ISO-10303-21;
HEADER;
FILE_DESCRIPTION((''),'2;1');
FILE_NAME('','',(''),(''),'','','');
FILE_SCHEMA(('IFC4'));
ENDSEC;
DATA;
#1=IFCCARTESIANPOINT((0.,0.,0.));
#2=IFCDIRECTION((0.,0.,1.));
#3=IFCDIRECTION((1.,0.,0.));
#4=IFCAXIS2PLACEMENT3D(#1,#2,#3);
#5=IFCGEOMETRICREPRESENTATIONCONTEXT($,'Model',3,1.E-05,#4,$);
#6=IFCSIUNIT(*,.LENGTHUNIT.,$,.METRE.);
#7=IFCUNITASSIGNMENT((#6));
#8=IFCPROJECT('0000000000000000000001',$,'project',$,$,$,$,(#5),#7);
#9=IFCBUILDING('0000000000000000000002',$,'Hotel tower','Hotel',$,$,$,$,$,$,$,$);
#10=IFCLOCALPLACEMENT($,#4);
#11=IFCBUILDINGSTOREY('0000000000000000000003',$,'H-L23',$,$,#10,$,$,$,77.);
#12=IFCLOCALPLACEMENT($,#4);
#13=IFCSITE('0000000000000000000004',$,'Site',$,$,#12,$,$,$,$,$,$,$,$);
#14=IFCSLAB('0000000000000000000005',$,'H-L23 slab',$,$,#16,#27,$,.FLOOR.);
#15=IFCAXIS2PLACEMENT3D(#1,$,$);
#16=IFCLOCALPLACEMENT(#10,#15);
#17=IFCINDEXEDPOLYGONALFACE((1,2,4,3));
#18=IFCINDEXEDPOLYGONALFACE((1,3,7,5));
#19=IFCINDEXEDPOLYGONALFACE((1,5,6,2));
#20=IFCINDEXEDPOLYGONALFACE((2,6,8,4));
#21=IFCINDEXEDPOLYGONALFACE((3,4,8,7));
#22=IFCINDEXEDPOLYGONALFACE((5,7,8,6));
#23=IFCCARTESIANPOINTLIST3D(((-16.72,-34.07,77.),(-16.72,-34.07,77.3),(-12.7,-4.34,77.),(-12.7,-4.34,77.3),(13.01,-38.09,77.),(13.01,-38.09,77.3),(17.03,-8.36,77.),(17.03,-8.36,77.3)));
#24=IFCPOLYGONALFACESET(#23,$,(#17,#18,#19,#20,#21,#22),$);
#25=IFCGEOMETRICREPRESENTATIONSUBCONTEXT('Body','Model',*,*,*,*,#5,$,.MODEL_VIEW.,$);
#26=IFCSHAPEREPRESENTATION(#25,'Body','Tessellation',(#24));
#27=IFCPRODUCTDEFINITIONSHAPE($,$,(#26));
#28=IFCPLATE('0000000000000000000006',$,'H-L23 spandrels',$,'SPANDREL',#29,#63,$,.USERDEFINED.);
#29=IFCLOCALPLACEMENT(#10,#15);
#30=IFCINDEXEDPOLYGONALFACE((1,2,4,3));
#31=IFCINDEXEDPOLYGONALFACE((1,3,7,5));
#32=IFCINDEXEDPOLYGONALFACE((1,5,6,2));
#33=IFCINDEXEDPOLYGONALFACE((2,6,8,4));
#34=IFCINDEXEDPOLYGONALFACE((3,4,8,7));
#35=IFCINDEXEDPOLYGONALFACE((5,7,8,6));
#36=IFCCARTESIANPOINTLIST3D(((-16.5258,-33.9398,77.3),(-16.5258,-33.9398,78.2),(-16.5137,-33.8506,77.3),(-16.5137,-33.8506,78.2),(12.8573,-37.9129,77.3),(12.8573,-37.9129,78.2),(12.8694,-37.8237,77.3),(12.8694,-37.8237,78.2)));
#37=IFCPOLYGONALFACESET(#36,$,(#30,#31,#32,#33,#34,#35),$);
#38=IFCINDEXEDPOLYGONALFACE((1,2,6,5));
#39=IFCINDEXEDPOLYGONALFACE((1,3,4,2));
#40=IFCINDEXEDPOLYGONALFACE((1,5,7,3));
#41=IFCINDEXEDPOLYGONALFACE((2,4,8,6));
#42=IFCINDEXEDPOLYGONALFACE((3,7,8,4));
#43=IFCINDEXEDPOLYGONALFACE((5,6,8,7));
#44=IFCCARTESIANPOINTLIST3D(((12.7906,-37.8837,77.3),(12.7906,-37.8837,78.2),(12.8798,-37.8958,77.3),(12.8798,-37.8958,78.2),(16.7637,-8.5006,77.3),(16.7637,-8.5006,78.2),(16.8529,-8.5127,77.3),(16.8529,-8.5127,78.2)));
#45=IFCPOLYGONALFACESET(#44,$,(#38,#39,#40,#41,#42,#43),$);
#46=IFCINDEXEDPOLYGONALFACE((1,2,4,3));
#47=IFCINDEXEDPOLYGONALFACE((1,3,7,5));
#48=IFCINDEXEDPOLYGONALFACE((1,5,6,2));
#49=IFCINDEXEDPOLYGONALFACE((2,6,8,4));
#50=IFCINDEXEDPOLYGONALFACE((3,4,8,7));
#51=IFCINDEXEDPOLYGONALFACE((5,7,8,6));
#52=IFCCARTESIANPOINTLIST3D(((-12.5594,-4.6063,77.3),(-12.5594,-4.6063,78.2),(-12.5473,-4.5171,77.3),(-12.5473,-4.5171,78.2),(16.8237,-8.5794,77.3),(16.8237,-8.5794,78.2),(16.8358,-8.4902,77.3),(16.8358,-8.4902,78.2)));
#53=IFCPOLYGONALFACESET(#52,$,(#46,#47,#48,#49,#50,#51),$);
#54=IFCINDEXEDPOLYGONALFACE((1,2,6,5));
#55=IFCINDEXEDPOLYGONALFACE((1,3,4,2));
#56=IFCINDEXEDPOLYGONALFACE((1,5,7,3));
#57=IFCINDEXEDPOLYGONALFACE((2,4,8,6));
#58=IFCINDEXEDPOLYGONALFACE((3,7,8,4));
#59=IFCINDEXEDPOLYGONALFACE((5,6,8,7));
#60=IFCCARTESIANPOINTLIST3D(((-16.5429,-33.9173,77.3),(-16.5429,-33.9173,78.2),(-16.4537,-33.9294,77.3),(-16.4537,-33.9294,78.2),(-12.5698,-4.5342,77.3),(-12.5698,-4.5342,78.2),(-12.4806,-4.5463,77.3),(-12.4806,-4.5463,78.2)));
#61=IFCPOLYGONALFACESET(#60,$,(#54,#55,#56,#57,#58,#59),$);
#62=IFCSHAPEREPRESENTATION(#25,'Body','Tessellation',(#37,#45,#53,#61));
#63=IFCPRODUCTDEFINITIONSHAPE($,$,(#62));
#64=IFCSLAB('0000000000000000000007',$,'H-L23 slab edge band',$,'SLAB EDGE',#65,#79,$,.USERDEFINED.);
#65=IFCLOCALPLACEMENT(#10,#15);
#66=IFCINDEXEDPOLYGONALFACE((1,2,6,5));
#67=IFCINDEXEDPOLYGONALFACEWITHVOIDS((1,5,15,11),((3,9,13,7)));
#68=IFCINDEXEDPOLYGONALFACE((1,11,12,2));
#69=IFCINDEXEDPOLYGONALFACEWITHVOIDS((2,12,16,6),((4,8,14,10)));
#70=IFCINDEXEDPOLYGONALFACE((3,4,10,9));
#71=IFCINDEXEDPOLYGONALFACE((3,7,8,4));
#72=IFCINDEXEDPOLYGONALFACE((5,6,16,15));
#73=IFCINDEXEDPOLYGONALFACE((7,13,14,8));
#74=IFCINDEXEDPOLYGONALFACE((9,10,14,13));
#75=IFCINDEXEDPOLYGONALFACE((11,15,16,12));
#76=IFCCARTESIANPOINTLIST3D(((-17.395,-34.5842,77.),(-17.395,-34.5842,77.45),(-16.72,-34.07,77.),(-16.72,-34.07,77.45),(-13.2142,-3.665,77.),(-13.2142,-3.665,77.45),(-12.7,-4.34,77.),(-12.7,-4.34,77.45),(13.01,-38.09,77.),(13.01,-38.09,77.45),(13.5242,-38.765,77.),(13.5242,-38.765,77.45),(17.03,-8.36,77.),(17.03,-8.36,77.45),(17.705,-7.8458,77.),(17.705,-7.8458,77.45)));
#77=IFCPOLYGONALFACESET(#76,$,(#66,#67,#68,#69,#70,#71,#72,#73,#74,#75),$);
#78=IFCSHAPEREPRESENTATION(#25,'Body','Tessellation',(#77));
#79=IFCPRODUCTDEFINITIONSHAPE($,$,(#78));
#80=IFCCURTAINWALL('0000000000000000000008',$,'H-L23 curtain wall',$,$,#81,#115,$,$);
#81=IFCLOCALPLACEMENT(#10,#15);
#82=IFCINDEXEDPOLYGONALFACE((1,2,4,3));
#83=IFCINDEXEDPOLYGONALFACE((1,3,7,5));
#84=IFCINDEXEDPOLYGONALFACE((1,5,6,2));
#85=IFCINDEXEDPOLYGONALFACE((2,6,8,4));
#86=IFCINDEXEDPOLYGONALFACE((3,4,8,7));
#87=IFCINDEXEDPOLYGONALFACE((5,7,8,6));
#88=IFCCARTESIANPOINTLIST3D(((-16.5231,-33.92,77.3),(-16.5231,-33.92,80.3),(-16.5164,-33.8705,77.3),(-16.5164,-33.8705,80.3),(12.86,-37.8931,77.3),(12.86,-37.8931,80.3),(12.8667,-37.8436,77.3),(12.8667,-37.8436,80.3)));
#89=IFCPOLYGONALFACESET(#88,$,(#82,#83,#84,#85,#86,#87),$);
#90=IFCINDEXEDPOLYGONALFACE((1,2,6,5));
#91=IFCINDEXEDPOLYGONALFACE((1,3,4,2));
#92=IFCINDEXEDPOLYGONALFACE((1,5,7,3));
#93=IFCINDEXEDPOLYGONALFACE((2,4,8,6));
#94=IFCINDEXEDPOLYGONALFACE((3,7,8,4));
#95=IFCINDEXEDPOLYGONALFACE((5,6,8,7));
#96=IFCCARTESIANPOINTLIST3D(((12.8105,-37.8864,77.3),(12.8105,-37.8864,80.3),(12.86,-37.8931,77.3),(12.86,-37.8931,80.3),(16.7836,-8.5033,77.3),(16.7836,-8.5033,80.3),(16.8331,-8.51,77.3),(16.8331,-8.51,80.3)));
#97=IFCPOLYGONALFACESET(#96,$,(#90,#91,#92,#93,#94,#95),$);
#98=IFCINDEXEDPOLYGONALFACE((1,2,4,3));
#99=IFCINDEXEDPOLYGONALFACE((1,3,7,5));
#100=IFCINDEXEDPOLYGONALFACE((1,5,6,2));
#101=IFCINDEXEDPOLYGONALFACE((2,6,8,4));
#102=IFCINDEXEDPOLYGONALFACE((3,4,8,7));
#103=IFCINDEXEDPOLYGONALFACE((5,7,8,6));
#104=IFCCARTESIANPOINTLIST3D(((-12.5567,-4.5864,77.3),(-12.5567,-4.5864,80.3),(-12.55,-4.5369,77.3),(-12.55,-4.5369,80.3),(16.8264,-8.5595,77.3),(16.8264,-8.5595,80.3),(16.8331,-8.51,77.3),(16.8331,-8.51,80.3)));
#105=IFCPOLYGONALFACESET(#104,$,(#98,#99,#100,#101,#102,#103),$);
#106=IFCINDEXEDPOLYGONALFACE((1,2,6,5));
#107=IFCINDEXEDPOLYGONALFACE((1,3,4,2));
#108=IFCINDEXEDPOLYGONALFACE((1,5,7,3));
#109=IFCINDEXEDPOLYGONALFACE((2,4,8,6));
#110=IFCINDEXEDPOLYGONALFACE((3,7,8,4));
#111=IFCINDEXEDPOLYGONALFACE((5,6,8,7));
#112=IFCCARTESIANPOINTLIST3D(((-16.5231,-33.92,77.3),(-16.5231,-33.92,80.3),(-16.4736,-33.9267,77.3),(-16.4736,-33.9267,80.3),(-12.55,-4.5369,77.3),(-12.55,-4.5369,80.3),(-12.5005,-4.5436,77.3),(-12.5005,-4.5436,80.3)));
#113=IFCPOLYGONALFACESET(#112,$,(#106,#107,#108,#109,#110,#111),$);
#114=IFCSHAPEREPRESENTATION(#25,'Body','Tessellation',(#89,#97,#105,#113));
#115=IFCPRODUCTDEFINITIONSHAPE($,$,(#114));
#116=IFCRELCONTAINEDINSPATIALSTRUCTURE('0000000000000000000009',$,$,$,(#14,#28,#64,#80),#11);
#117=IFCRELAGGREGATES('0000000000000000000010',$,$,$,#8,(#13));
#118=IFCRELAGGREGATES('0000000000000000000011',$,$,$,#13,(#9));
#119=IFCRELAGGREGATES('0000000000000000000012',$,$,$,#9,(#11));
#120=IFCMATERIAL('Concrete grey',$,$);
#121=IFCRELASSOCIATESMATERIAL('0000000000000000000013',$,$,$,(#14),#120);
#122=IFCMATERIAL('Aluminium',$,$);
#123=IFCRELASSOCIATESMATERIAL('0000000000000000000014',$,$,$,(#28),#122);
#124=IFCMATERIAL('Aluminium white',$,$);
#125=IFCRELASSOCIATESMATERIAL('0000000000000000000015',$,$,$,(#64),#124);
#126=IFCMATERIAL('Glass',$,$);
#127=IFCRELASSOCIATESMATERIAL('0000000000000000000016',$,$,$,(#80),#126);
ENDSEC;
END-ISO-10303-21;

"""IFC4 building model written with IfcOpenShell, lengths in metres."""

from ifc_helpers import new_model, si_unit, frame, origin_with_axes, place, context, subcontext, project, spatial, polyline, outline, extrude, material, element, save


model = new_model("IFC4")

# Units and contexts
model_context = context("Model", 3, precision=1e-05, world=origin_with_axes())
body_context = subcontext(model_context, "Body", "Model", "MODEL_VIEW")
ifc_project = project(units=[si_unit("LENGTHUNIT", "METRE")], contexts=[model_context])

# Site, building, storey
site_placement = place(None, origin_with_axes())
site = spatial("IfcSite", under=ifc_project, at=site_placement, Name="Site")
building = spatial("IfcBuilding", under=site, Name="Hotel tower", Description="Hotel")
storey_placement = place(None, origin_with_axes())
storey = spatial("IfcBuildingStorey", under=building, at=storey_placement, Name="H-L23", Elevation=77.0)

# Shared definitions
ifc_material_1 = material(Name="Aluminium")

# Slab
ifc_material_2 = material(Name="Concrete grey")
slab_1_placement = place(storey_placement, origin_with_axes())
element("IfcSlab", 1, at=slab_1_placement, inside=storey, material=ifc_material_2, Name="H-L23 slab", PredefinedType="FLOOR", context=body_context, shape_type="SweptSolid", body=[
    extrude(outline(polyline([(-16.72, -34.07), (13.01, -38.09), (17.03, -8.36), (-12.7, -4.34), (-16.72, -34.07)])), frame((0.0, 0.0, 77.0), z_axis=(0.0, 0.0, 1.0), x_axis=(1.0, 0.0, 0.0)), (0.0, 0.0, 1.0), 0.3),
])

# Plate
plate_placement = place(storey_placement, origin_with_axes())
element("IfcPlate", 2, at=plate_placement, inside=storey, material=ifc_material_1, Name="H-L23 spandrels", ObjectType="SPANDREL", PredefinedType="USERDEFINED", context=body_context, shape_type="SweptSolid", body=[
    extrude(outline(polyline([(-16.5258, -33.9398), (12.8573, -37.9129), (12.8694, -37.8237), (-16.5137, -33.8506), (-16.5258, -33.9398)])), frame((0.0, 0.0, 77.3), z_axis=(0.0, 0.0, 1.0), x_axis=(1.0, 0.0, 0.0)), (0.0, 0.0, 1.0), 0.9),
    extrude(outline(polyline([(12.8798, -37.8958), (16.8529, -8.5127), (16.7637, -8.5006), (12.7906, -37.8837), (12.8798, -37.8958)])), frame((0.0, 0.0, 77.3), z_axis=(0.0, 0.0, 1.0), x_axis=(1.0, 0.0, 0.0)), (0.0, 0.0, 1.0), 0.9),
    extrude(outline(polyline([(16.8358, -8.4902), (-12.5473, -4.5171), (-12.5594, -4.6063), (16.8237, -8.5794), (16.8358, -8.4902)])), frame((0.0, 0.0, 77.3), z_axis=(0.0, 0.0, 1.0), x_axis=(1.0, 0.0, 0.0)), (0.0, 0.0, 1.0), 0.9),
    extrude(outline(polyline([(-12.5698, -4.5342), (-16.5429, -33.9173), (-16.4537, -33.9294), (-12.4806, -4.5463), (-12.5698, -4.5342)])), frame((0.0, 0.0, 77.3), z_axis=(0.0, 0.0, 1.0), x_axis=(1.0, 0.0, 0.0)), (0.0, 0.0, 1.0), 0.9),
])

# Slab
ifc_material_3 = material(Name="Aluminium white")
slab_2_placement = place(storey_placement, origin_with_axes())
element("IfcSlab", 3, at=slab_2_placement, inside=storey, material=ifc_material_3, Name="H-L23 slab edge band", ObjectType="SLAB EDGE", PredefinedType="USERDEFINED", context=body_context, shape_type="SweptSolid", body=[
    extrude(outline(polyline([(-17.395, -34.5842), (13.5242, -38.765), (17.705, -7.8458), (-13.2142, -3.665), (-17.395, -34.5842)]), holes=[polyline([(-16.72, -34.07), (13.01, -38.09), (17.03, -8.36), (-12.7, -4.34), (-16.72, -34.07)])]), frame((0.0, 0.0, 77.0), z_axis=(0.0, 0.0, 1.0), x_axis=(1.0, 0.0, 0.0)), (0.0, 0.0, 1.0), 0.45),
])

# Curtain wall
ifc_material_4 = material(Name="Glass")
curtain_wall_placement = place(storey_placement, origin_with_axes())
element("IfcCurtainWall", 4, at=curtain_wall_placement, inside=storey, material=ifc_material_4, Name="H-L23 curtain wall", context=body_context, shape_type="SweptSolid", body=[
    extrude(outline(polyline([(-16.5231, -33.92), (12.86, -37.8931), (12.8667, -37.8436), (-16.5164, -33.8705), (-16.5231, -33.92)])), frame((0.0, 0.0, 77.3), z_axis=(0.0, 0.0, 1.0), x_axis=(1.0, 0.0, 0.0)), (0.0, 0.0, 1.0), 3.0),
    extrude(outline(polyline([(12.86, -37.8931), (16.8331, -8.51), (16.7836, -8.5033), (12.8105, -37.8864), (12.86, -37.8931)])), frame((0.0, 0.0, 77.3), z_axis=(0.0, 0.0, 1.0), x_axis=(1.0, 0.0, 0.0)), (0.0, 0.0, 1.0), 3.0),
    extrude(outline(polyline([(16.8331, -8.51), (-12.55, -4.5369), (-12.5567, -4.5864), (16.8264, -8.5595), (16.8331, -8.51)])), frame((0.0, 0.0, 77.3), z_axis=(0.0, 0.0, 1.0), x_axis=(1.0, 0.0, 0.0)), (0.0, 0.0, 1.0), 3.0),
    extrude(outline(polyline([(-12.55, -4.5369), (-16.5231, -33.92), (-16.4736, -33.9267), (-12.5005, -4.5436), (-12.55, -4.5369)])), frame((0.0, 0.0, 77.3), z_axis=(0.0, 0.0, 1.0), x_axis=(1.0, 0.0, 0.0)), (0.0, 0.0, 1.0), 3.0),
])

save(model, "model.ifc")
